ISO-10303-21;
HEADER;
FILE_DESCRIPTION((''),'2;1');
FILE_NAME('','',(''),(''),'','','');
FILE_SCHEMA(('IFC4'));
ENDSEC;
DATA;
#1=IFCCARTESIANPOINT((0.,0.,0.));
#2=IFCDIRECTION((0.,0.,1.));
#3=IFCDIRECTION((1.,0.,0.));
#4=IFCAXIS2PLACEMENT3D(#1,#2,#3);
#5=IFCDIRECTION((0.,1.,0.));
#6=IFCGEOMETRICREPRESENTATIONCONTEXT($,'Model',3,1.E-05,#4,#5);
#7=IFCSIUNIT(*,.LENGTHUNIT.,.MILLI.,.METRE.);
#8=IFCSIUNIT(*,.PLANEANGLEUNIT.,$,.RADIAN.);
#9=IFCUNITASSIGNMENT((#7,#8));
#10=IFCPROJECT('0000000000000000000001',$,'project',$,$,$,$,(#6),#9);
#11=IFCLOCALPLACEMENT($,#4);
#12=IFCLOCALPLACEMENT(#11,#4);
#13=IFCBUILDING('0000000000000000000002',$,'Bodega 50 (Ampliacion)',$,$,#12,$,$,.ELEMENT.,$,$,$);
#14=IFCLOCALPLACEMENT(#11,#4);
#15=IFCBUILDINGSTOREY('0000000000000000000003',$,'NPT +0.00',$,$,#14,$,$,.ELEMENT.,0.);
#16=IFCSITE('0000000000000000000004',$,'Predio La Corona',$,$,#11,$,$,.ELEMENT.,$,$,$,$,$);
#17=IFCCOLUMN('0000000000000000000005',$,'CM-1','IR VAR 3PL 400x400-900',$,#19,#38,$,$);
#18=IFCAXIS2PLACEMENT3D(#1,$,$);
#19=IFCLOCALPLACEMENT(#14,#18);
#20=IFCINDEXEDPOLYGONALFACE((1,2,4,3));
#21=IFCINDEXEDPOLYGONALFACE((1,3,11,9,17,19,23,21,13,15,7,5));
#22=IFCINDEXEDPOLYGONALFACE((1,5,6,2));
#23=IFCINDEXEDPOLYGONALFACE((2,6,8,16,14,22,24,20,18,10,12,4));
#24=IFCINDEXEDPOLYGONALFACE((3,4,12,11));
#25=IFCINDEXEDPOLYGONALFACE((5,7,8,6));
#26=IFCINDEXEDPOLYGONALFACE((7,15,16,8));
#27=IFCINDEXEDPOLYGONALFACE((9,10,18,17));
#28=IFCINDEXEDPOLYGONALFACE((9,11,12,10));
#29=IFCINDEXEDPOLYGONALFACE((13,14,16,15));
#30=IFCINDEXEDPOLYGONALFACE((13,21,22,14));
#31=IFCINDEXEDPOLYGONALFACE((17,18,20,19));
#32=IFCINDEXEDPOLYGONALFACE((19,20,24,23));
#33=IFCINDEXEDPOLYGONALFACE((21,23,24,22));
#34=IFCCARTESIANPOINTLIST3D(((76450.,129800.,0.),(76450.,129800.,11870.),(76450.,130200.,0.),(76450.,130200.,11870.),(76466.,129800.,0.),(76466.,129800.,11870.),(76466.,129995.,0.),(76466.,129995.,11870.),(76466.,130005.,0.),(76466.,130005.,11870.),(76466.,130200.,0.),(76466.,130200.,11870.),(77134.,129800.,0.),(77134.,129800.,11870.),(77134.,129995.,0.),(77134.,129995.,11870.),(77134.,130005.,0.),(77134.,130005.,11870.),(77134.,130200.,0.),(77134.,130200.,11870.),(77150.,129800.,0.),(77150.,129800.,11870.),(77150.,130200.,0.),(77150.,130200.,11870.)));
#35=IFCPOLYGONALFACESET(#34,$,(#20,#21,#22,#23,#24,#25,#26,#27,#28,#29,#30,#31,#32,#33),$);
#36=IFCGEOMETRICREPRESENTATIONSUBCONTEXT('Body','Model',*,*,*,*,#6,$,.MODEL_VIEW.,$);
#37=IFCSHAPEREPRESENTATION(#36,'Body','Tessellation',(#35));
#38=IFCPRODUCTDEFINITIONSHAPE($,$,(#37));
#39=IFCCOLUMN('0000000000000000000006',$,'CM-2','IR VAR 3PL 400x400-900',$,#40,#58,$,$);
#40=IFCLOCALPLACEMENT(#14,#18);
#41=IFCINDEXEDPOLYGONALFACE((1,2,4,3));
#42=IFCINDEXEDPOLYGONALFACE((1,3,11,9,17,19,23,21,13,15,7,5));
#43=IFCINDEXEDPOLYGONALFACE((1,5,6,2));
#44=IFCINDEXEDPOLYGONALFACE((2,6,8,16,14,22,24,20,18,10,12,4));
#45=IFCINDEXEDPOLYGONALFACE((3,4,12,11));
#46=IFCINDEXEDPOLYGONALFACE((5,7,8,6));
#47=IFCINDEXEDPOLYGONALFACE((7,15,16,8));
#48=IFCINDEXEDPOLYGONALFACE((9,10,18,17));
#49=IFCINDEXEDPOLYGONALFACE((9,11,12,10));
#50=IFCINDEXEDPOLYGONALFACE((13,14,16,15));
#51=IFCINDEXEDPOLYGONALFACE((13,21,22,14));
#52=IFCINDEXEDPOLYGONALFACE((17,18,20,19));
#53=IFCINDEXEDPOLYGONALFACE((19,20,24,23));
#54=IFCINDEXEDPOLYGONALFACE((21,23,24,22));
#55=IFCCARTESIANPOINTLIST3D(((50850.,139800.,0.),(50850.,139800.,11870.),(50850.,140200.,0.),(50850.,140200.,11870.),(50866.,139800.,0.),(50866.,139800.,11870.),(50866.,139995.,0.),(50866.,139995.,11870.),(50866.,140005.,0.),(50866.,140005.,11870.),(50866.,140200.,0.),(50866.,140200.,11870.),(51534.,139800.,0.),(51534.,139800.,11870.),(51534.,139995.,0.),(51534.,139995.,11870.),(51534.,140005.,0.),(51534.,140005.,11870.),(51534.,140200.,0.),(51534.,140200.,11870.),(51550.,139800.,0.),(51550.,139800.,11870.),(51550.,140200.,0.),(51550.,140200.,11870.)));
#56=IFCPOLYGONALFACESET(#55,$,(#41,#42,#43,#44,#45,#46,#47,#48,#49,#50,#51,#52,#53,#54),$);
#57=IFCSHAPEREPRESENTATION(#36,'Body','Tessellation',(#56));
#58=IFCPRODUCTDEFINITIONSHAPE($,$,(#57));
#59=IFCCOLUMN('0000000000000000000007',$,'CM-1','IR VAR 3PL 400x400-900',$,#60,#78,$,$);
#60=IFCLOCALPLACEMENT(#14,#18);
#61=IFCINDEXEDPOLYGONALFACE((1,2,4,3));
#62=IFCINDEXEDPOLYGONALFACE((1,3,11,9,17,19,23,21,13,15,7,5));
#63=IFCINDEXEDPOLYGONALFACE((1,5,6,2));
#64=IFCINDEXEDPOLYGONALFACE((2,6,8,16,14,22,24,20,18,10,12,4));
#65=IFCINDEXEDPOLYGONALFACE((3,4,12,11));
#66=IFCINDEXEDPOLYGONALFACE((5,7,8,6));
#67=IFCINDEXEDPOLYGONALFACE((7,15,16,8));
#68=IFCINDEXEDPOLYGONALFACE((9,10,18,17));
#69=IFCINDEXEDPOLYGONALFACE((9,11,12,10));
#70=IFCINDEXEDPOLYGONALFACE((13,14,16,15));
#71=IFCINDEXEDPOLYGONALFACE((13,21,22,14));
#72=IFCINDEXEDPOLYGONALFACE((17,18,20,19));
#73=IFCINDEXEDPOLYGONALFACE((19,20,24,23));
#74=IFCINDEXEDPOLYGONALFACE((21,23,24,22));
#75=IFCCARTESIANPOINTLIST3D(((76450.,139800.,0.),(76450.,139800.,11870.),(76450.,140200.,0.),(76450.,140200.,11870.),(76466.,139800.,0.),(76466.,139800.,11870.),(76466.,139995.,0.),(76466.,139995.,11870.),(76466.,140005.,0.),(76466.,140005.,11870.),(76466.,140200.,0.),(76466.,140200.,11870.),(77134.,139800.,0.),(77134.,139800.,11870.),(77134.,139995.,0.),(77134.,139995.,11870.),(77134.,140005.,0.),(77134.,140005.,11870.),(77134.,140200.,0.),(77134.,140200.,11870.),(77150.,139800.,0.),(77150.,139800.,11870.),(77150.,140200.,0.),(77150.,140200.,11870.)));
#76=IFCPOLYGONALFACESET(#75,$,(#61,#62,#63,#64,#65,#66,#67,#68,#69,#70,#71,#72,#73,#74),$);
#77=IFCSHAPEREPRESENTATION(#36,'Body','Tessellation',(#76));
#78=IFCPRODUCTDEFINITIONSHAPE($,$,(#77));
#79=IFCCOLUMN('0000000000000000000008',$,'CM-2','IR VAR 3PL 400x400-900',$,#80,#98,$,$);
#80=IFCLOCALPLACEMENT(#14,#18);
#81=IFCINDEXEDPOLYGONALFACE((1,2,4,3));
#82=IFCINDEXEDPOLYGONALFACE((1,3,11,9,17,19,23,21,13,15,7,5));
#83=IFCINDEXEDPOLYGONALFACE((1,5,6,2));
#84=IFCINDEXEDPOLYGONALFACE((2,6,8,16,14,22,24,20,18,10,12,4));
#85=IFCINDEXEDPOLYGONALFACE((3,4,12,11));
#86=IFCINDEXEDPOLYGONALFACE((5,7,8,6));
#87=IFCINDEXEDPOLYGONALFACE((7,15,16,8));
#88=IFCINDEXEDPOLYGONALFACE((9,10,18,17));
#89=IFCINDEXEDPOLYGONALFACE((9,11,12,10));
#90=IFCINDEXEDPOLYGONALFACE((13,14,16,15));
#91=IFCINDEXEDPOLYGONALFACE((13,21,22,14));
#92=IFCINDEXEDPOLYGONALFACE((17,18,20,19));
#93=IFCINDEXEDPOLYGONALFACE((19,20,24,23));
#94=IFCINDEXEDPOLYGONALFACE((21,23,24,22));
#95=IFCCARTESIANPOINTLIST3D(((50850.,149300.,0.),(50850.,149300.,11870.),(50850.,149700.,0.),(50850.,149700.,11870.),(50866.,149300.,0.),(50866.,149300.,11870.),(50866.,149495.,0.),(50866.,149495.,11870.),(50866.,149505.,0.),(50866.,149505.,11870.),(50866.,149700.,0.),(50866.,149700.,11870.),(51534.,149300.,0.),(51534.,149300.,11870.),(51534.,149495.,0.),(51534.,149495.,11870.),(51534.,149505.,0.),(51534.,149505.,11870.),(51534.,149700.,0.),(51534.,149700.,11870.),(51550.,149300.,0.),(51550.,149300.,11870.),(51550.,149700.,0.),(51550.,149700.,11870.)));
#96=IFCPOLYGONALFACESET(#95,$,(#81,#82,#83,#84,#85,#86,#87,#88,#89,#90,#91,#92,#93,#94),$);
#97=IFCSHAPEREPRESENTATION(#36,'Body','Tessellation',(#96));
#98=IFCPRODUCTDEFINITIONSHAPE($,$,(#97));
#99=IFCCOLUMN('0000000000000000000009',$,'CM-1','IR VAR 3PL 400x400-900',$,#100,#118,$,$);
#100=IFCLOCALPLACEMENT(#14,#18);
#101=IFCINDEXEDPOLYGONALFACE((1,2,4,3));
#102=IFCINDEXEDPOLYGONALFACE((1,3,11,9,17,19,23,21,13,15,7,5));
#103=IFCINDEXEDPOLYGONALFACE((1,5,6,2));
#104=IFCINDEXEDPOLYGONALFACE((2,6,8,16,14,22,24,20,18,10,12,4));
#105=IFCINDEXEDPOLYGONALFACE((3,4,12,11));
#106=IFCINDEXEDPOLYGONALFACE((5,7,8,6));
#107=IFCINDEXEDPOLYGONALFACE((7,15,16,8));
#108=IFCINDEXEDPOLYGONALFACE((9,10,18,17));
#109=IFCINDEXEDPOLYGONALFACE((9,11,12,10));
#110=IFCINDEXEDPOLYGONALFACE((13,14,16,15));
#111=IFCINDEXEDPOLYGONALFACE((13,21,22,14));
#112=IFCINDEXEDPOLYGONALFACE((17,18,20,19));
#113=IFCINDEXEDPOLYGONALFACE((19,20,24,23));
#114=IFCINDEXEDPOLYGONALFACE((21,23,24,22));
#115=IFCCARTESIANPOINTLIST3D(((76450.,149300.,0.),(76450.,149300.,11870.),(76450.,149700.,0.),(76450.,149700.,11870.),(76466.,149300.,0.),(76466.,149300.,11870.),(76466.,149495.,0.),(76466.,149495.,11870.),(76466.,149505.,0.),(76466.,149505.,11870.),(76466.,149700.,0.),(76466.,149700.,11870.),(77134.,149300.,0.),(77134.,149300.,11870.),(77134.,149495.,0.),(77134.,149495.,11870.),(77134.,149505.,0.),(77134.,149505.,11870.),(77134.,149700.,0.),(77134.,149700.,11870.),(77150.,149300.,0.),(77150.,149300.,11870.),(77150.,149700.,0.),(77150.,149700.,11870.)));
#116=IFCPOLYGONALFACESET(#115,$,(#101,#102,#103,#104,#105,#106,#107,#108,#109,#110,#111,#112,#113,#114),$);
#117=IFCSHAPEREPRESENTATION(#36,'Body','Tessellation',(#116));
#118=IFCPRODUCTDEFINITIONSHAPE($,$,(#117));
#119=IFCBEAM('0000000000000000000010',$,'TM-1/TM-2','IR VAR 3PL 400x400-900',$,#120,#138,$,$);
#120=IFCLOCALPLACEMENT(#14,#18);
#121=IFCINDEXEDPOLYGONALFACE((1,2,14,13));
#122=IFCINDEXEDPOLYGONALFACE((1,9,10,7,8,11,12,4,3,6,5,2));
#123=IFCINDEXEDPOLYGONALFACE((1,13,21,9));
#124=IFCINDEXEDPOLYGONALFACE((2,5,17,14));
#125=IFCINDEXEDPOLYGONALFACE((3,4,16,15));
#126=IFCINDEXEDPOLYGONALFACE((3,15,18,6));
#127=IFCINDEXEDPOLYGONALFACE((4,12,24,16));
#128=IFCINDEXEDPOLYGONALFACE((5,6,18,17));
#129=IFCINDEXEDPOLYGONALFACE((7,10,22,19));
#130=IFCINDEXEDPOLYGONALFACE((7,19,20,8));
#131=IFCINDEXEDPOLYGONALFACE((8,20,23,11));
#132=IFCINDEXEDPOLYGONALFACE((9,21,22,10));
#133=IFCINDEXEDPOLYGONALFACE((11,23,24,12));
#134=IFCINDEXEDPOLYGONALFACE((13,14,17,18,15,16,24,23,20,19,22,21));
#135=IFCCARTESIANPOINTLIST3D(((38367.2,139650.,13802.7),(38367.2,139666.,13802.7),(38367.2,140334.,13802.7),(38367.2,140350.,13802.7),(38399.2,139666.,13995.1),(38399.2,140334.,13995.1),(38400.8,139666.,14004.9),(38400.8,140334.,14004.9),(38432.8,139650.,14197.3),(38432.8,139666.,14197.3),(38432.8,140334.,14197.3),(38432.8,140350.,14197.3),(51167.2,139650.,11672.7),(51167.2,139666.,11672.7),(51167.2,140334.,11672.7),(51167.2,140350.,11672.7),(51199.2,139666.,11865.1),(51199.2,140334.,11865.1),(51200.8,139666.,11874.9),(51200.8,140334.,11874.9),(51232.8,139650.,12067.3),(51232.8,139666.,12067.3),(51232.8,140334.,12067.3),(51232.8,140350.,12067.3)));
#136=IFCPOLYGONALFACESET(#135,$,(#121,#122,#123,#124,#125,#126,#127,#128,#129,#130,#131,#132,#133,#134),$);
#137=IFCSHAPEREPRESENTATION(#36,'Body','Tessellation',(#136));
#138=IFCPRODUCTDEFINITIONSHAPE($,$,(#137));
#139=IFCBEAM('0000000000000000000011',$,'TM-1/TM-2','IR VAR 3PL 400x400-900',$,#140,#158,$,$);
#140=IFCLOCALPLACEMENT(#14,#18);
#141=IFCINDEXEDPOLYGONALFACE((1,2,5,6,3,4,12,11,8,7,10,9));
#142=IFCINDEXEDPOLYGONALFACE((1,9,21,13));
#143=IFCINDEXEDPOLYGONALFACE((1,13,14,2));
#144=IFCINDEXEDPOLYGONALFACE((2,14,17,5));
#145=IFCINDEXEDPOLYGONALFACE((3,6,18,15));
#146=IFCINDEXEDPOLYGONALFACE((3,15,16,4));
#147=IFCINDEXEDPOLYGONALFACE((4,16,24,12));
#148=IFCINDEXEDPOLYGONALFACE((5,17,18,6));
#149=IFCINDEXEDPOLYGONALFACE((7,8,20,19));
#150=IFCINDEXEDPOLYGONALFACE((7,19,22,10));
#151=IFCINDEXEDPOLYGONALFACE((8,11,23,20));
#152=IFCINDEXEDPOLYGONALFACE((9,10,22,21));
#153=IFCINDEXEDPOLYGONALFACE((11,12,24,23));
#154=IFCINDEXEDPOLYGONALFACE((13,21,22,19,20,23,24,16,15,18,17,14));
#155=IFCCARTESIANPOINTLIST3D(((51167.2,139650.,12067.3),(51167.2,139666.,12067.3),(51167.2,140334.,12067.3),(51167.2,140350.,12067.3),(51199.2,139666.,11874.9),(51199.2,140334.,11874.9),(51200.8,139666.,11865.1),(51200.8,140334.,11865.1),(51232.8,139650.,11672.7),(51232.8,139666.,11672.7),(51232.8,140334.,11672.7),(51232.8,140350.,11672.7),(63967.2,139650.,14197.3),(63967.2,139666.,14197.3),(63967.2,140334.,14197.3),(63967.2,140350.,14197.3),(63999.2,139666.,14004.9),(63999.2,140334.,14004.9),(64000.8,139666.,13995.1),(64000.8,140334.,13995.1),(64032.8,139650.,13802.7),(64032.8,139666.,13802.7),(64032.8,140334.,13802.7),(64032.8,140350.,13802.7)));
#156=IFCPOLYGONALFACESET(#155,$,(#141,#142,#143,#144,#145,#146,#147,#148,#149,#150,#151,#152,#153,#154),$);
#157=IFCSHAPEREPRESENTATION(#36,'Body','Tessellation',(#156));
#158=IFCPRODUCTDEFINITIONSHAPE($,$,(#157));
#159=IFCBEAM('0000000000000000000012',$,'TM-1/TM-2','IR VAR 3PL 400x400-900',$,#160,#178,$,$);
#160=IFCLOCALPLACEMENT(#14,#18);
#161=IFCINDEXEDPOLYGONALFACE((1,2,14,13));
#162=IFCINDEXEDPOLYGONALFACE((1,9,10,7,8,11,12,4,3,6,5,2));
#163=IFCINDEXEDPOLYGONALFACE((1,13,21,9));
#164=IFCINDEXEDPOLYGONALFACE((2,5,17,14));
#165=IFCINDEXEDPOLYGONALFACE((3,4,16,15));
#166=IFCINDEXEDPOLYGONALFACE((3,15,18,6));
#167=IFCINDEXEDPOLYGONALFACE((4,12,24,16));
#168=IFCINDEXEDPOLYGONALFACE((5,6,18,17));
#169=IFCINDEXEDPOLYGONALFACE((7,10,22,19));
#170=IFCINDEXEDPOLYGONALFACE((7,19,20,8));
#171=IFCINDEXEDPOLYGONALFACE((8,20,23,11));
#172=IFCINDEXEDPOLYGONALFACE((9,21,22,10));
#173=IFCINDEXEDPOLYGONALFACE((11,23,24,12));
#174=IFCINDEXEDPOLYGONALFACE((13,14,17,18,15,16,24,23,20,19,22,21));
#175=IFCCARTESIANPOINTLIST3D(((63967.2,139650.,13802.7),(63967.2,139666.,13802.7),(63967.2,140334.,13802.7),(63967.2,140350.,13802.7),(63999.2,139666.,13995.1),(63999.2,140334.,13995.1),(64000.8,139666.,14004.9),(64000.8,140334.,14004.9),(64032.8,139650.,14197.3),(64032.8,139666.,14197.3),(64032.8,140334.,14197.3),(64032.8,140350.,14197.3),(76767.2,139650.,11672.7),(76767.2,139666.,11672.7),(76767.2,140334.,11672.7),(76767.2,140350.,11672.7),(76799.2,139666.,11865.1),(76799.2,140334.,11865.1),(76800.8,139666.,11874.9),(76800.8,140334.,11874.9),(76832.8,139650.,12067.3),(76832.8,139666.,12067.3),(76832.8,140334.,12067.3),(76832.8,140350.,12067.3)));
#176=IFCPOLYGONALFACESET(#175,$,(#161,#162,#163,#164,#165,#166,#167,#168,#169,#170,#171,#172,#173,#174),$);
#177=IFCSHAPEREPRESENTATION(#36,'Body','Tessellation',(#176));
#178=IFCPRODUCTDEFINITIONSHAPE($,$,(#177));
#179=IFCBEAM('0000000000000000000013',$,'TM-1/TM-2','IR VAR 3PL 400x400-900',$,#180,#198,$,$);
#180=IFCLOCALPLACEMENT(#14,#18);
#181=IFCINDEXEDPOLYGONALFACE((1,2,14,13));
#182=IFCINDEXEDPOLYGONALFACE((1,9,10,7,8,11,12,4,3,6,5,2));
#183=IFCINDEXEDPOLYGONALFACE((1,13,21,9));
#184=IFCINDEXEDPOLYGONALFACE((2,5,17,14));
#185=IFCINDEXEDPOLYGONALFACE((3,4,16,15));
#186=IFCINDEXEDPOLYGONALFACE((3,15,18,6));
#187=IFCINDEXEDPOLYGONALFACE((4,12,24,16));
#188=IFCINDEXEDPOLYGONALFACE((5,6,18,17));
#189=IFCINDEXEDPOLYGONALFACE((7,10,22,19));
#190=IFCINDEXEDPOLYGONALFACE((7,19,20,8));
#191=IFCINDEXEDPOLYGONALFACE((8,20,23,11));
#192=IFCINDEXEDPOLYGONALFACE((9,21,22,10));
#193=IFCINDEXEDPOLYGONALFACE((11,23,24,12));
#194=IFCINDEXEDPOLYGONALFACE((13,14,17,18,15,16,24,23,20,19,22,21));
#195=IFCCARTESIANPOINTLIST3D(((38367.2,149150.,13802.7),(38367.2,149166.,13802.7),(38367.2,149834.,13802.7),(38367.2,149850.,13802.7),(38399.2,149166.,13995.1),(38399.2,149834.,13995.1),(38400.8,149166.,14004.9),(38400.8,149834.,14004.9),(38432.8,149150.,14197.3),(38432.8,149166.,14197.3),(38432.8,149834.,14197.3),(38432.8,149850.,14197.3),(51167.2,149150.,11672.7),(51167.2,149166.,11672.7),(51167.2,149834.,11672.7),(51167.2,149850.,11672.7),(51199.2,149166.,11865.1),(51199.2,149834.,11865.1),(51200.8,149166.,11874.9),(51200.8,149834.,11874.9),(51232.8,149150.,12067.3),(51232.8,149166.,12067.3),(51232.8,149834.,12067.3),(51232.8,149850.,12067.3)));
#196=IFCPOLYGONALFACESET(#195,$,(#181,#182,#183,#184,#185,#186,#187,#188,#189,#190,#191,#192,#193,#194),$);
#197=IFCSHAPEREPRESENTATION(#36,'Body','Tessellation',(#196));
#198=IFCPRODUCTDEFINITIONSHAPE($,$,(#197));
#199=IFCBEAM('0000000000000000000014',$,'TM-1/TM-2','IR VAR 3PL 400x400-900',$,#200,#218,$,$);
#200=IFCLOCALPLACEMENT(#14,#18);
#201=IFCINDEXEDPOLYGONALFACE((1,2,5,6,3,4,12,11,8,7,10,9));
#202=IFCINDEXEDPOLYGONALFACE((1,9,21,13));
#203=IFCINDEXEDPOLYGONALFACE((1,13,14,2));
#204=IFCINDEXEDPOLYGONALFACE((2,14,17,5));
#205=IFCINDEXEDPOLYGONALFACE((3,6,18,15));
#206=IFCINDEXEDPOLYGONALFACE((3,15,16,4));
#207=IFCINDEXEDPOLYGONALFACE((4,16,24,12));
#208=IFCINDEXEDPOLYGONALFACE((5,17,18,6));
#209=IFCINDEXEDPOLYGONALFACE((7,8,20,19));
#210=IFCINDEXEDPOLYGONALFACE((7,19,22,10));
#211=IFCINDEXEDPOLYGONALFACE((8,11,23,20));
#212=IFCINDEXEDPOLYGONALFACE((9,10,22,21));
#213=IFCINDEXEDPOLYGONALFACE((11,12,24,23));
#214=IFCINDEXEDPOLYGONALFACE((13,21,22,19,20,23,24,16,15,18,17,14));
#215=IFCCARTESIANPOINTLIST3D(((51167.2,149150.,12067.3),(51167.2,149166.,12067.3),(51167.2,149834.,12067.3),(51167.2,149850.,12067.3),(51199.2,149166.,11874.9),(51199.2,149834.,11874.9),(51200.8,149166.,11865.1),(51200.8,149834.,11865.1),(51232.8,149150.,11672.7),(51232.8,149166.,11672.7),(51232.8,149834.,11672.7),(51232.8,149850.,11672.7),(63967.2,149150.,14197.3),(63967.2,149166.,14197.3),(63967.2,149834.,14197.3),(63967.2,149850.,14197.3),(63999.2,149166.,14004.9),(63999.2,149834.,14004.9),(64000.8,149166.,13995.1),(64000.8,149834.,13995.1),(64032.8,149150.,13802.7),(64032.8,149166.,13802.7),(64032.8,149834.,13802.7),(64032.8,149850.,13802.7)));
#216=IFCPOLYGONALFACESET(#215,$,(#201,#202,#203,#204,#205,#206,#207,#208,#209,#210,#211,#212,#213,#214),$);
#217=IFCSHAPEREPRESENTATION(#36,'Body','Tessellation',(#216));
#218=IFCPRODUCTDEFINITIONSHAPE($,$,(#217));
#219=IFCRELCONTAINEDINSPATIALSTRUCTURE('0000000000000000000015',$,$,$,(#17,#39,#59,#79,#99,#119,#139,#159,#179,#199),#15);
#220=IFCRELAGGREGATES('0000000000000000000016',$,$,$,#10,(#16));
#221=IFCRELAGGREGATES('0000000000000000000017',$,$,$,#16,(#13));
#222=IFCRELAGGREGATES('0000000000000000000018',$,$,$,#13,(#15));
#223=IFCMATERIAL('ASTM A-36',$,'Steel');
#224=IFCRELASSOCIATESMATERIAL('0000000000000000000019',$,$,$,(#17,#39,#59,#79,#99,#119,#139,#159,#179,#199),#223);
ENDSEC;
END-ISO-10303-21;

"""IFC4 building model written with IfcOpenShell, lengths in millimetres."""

from ifc_helpers import new_model, si_unit, direction, frame, origin_with_axes, origin_2d, place, context, subcontext, project, spatial, i_section, extrude, material, element, save


model = new_model("IFC4")

# Units and contexts
model_context = context("Model", 3, precision=1e-05, world=origin_with_axes(), true_north=direction((0.0, 1.0, 0.0)))
body_context = subcontext(model_context, "Body", "Model", "MODEL_VIEW")
ifc_project = project(units=[si_unit("LENGTHUNIT", "METRE", prefix="MILLI"), si_unit("PLANEANGLEUNIT", "RADIAN")], contexts=[model_context])

# Site, building, storey
site_placement = place(None, origin_with_axes())
site = spatial("IfcSite", under=ifc_project, at=site_placement, Name="Predio La Corona", CompositionType="ELEMENT")
building_placement = place(site_placement, origin_with_axes())
building = spatial("IfcBuilding", under=site, at=building_placement, Name="Bodega 50 (Ampliacion)", CompositionType="ELEMENT")
storey_placement = place(site_placement, origin_with_axes())
storey = spatial("IfcBuildingStorey", under=building, at=storey_placement, Name="NPT +0.00", CompositionType="ELEMENT", Elevation=0.0)

# Columns
ifc_material = material(Name="ASTM A-36", Category="Steel")
for number, where, z_axis, x_axis, name in (
    (1, (76800.0, 130000.0, 0.0), (0.0, 0.0, 1.0), (0.0, -1.0, 0.0), "CM-1"),
    (2, (51200.0, 140000.0, 0.0), (0.0, 0.0, 1.0), (0.0, -1.0, 0.0), "CM-2"),
    (3, (76800.0, 140000.0, 0.0), (0.0, 0.0, 1.0), (0.0, -1.0, 0.0), "CM-1"),
    (4, (51200.0, 149500.0, 0.0), (0.0, 0.0, 1.0), (0.0, -1.0, 0.0), "CM-2"),
    (5, (76800.0, 149500.0, 0.0), (0.0, 0.0, 1.0), (0.0, -1.0, 0.0), "CM-1"),
):
    element("IfcColumn", number, at=place(storey_placement, frame(where, z_axis=z_axis, x_axis=x_axis)), inside=storey, material=ifc_material, Name=name, Description="IR VAR 3PL 400x400-900", context=body_context, shape_type="SweptSolid", body=[
        extrude(i_section(OverallWidth=400.0, OverallDepth=700.0, WebThickness=10.0, FlangeThickness=16.0, at=origin_2d()), origin_with_axes(), (0.0, 0.0, 1.0), 11870.0),
    ])

# Beams
for number, where, z_axis, x_axis, name in (
    (6, (38400.0, 140000.0, 14000.0), (0.986436, 0.0, -0.164149), (-0.164149, 0.0, -0.986436), "TM-1/TM-2"),
    (7, (51200.0, 140000.0, 11870.0), (0.986436, 0.0, 0.164149), (0.164149, 0.0, -0.986436), "TM-1/TM-2"),
    (8, (64000.0, 140000.0, 14000.0), (0.986436, 0.0, -0.164149), (-0.164149, 0.0, -0.986436), "TM-1/TM-2"),
    (9, (38400.0, 149500.0, 14000.0), (0.986436, 0.0, -0.164149), (-0.164149, 0.0, -0.986436), "TM-1/TM-2"),
    (10, (51200.0, 149500.0, 11870.0), (0.986436, 0.0, 0.164149), (0.164149, 0.0, -0.986436), "TM-1/TM-2"),
):
    element("IfcBeam", number, at=place(storey_placement, frame(where, z_axis=z_axis, x_axis=x_axis)), inside=storey, material=ifc_material, Name=name, Description="IR VAR 3PL 400x400-900", context=body_context, shape_type="SweptSolid", body=[
        extrude(i_section(OverallWidth=400.0, OverallDepth=700.0, WebThickness=10.0, FlangeThickness=16.0, at=origin_2d()), origin_with_axes(), (0.0, 0.0, 1.0), 12976.0),
    ])

save(model, "model.ifc")
